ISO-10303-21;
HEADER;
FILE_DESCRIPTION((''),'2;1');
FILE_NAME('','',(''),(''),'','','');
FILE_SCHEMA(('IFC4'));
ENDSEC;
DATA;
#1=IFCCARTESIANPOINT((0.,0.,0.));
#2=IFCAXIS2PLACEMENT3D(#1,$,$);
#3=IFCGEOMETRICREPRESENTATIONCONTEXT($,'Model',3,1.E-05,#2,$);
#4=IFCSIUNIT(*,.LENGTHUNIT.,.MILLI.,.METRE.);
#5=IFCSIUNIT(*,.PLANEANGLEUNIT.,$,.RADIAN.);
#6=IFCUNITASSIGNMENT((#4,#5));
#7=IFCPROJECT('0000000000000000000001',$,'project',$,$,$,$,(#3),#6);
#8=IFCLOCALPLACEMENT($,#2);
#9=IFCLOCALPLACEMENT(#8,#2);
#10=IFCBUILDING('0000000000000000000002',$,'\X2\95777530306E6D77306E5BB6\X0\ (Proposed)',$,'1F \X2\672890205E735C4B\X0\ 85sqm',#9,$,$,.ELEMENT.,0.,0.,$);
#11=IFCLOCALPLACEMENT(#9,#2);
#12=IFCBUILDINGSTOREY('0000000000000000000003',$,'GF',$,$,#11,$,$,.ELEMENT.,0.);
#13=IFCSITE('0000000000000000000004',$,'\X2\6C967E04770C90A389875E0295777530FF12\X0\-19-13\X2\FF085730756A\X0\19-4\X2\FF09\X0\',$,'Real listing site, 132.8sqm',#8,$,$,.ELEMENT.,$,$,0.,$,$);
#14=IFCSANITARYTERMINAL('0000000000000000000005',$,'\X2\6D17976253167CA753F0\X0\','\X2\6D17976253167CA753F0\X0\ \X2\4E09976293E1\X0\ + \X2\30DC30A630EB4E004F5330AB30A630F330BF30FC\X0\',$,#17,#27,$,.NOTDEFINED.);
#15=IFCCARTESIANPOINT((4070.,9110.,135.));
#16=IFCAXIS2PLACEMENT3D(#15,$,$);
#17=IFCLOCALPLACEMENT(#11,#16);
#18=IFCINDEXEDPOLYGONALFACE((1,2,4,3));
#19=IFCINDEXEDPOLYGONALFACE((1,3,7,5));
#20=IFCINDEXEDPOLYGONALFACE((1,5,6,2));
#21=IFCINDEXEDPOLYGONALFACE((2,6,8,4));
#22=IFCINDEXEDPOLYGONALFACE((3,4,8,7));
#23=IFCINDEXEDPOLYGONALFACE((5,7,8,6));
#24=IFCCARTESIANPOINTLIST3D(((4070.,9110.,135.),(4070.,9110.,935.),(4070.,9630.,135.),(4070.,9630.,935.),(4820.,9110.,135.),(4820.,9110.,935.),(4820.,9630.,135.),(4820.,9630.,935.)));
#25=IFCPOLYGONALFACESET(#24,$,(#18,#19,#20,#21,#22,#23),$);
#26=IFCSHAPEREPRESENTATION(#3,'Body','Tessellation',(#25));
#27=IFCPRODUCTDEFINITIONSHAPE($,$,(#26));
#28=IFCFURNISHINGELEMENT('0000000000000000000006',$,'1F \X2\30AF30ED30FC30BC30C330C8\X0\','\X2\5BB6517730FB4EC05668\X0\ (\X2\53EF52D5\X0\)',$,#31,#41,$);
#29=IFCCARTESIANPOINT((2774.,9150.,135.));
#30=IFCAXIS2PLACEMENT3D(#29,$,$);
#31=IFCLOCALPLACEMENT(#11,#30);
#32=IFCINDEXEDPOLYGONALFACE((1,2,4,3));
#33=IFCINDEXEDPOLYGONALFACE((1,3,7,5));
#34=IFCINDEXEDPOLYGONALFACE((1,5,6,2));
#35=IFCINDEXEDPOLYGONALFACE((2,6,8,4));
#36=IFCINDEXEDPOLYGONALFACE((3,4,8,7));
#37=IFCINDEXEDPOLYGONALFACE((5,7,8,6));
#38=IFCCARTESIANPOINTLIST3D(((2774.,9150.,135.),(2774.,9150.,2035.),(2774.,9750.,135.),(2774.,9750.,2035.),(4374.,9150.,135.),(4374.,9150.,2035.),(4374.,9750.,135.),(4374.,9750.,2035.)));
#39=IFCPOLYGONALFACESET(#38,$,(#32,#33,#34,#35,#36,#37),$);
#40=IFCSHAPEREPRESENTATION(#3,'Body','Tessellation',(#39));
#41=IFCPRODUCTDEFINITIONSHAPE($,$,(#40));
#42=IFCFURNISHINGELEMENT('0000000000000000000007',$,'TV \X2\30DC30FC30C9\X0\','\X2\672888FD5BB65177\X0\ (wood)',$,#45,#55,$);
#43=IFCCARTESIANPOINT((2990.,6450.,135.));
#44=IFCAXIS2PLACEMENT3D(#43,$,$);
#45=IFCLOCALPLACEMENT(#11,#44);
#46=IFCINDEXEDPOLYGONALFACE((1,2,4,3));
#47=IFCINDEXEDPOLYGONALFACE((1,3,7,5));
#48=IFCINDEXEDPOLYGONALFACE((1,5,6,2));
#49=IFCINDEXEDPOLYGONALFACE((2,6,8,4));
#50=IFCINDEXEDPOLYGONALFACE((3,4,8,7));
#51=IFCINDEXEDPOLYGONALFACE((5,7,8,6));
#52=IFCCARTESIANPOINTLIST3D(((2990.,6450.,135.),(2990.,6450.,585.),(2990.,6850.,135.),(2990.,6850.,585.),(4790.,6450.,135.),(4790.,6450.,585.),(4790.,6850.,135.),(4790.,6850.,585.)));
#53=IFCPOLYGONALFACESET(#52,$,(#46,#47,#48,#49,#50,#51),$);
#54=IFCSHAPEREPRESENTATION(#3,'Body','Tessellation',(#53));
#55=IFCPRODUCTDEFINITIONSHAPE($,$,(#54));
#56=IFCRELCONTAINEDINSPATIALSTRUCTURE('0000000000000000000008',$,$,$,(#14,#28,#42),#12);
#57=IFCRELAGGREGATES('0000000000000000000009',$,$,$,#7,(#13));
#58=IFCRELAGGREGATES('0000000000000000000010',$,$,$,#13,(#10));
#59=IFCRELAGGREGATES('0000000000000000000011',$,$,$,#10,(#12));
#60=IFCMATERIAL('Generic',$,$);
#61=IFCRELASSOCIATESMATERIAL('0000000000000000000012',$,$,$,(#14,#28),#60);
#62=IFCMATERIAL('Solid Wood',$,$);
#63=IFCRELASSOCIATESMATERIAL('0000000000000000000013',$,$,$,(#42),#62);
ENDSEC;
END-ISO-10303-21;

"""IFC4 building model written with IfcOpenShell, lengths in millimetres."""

from ifc_helpers import new_model, si_unit, frame, frame_2d, origin, place, context, project, spatial, rectangle, extrude, material, element, save


model = new_model("IFC4")

# Units and contexts
model_context = context("Model", 3, precision=1e-05, world=origin())
ifc_project = project(units=[si_unit("LENGTHUNIT", "METRE", prefix="MILLI"), si_unit("PLANEANGLEUNIT", "RADIAN")], contexts=[model_context])

# Site, building, storey
site_placement = place(None, origin())
site = spatial("IfcSite", under=ifc_project, at=site_placement, Name="沖縄県那覇市長田２-19-13（地番19-4）", ObjectType="Real listing site, 132.8sqm", CompositionType="ELEMENT", RefElevation=0.0)
building_placement = place(site_placement, origin())
building = spatial("IfcBuilding", under=site, at=building_placement, Name="長田の海の家 (Proposed)", ObjectType="1F 木造平屋 85sqm", CompositionType="ELEMENT", ElevationOfRefHeight=0.0, ElevationOfTerrain=0.0)
storey_placement = place(building_placement, origin())
storey = spatial("IfcBuildingStorey", under=building, at=storey_placement, Name="GF", CompositionType="ELEMENT", Elevation=0.0)

# Shared definitions
ifc_material_1 = material(Name="Solid Wood")

# Shared definitions
ifc_material_2 = material(Name="Generic")

# Sanitary terminal
sanitary_terminal_1_placement = place(storey_placement, frame((4070.0, 9110.0, 135.0)))
element("IfcSanitaryTerminal", 1, at=sanitary_terminal_1_placement, inside=storey, material=ifc_material_2, Name="洗面化粧台", Description="洗面化粧台 三面鏡 + ボウル一体カウンター", PredefinedType="NOTDEFINED", context=model_context, shape_type="SweptSolid", body=[
    extrude(rectangle(XDim=750.0, YDim=520.0, at=frame_2d((375.0, 260.0))), frame((4070.0, 9110.0, 135.0)), (0.0, 0.0, 1.0), 800.0),
])

# Furnishing elements
furnishing_1_placement = place(storey_placement, frame((2774.0, 9150.0, 135.0)))
element("IfcFurnishingElement", 2, at=furnishing_1_placement, inside=storey, material=ifc_material_2, Name="1F クローゼット", Description="家具・什器 (可動)", context=model_context, shape_type="SweptSolid", body=[
    extrude(rectangle(XDim=1600.0, YDim=600.0, at=frame_2d((800.0, 300.0))), frame((2774.0, 9150.0, 135.0)), (0.0, 0.0, 1.0), 1900.0),
])
furnishing_2_placement = place(storey_placement, frame((2990.0, 6450.0, 135.0)))
element("IfcFurnishingElement", 3, at=furnishing_2_placement, inside=storey, material=ifc_material_1, Name="TV ボード", Description="木製家具 (wood)", context=model_context, shape_type="SweptSolid", body=[
    extrude(rectangle(XDim=1800.0, YDim=400.0, at=frame_2d((900.0, 200.0))), frame((2990.0, 6450.0, 135.0)), (0.0, 0.0, 1.0), 450.0),
])

save(model, "model.ifc")
